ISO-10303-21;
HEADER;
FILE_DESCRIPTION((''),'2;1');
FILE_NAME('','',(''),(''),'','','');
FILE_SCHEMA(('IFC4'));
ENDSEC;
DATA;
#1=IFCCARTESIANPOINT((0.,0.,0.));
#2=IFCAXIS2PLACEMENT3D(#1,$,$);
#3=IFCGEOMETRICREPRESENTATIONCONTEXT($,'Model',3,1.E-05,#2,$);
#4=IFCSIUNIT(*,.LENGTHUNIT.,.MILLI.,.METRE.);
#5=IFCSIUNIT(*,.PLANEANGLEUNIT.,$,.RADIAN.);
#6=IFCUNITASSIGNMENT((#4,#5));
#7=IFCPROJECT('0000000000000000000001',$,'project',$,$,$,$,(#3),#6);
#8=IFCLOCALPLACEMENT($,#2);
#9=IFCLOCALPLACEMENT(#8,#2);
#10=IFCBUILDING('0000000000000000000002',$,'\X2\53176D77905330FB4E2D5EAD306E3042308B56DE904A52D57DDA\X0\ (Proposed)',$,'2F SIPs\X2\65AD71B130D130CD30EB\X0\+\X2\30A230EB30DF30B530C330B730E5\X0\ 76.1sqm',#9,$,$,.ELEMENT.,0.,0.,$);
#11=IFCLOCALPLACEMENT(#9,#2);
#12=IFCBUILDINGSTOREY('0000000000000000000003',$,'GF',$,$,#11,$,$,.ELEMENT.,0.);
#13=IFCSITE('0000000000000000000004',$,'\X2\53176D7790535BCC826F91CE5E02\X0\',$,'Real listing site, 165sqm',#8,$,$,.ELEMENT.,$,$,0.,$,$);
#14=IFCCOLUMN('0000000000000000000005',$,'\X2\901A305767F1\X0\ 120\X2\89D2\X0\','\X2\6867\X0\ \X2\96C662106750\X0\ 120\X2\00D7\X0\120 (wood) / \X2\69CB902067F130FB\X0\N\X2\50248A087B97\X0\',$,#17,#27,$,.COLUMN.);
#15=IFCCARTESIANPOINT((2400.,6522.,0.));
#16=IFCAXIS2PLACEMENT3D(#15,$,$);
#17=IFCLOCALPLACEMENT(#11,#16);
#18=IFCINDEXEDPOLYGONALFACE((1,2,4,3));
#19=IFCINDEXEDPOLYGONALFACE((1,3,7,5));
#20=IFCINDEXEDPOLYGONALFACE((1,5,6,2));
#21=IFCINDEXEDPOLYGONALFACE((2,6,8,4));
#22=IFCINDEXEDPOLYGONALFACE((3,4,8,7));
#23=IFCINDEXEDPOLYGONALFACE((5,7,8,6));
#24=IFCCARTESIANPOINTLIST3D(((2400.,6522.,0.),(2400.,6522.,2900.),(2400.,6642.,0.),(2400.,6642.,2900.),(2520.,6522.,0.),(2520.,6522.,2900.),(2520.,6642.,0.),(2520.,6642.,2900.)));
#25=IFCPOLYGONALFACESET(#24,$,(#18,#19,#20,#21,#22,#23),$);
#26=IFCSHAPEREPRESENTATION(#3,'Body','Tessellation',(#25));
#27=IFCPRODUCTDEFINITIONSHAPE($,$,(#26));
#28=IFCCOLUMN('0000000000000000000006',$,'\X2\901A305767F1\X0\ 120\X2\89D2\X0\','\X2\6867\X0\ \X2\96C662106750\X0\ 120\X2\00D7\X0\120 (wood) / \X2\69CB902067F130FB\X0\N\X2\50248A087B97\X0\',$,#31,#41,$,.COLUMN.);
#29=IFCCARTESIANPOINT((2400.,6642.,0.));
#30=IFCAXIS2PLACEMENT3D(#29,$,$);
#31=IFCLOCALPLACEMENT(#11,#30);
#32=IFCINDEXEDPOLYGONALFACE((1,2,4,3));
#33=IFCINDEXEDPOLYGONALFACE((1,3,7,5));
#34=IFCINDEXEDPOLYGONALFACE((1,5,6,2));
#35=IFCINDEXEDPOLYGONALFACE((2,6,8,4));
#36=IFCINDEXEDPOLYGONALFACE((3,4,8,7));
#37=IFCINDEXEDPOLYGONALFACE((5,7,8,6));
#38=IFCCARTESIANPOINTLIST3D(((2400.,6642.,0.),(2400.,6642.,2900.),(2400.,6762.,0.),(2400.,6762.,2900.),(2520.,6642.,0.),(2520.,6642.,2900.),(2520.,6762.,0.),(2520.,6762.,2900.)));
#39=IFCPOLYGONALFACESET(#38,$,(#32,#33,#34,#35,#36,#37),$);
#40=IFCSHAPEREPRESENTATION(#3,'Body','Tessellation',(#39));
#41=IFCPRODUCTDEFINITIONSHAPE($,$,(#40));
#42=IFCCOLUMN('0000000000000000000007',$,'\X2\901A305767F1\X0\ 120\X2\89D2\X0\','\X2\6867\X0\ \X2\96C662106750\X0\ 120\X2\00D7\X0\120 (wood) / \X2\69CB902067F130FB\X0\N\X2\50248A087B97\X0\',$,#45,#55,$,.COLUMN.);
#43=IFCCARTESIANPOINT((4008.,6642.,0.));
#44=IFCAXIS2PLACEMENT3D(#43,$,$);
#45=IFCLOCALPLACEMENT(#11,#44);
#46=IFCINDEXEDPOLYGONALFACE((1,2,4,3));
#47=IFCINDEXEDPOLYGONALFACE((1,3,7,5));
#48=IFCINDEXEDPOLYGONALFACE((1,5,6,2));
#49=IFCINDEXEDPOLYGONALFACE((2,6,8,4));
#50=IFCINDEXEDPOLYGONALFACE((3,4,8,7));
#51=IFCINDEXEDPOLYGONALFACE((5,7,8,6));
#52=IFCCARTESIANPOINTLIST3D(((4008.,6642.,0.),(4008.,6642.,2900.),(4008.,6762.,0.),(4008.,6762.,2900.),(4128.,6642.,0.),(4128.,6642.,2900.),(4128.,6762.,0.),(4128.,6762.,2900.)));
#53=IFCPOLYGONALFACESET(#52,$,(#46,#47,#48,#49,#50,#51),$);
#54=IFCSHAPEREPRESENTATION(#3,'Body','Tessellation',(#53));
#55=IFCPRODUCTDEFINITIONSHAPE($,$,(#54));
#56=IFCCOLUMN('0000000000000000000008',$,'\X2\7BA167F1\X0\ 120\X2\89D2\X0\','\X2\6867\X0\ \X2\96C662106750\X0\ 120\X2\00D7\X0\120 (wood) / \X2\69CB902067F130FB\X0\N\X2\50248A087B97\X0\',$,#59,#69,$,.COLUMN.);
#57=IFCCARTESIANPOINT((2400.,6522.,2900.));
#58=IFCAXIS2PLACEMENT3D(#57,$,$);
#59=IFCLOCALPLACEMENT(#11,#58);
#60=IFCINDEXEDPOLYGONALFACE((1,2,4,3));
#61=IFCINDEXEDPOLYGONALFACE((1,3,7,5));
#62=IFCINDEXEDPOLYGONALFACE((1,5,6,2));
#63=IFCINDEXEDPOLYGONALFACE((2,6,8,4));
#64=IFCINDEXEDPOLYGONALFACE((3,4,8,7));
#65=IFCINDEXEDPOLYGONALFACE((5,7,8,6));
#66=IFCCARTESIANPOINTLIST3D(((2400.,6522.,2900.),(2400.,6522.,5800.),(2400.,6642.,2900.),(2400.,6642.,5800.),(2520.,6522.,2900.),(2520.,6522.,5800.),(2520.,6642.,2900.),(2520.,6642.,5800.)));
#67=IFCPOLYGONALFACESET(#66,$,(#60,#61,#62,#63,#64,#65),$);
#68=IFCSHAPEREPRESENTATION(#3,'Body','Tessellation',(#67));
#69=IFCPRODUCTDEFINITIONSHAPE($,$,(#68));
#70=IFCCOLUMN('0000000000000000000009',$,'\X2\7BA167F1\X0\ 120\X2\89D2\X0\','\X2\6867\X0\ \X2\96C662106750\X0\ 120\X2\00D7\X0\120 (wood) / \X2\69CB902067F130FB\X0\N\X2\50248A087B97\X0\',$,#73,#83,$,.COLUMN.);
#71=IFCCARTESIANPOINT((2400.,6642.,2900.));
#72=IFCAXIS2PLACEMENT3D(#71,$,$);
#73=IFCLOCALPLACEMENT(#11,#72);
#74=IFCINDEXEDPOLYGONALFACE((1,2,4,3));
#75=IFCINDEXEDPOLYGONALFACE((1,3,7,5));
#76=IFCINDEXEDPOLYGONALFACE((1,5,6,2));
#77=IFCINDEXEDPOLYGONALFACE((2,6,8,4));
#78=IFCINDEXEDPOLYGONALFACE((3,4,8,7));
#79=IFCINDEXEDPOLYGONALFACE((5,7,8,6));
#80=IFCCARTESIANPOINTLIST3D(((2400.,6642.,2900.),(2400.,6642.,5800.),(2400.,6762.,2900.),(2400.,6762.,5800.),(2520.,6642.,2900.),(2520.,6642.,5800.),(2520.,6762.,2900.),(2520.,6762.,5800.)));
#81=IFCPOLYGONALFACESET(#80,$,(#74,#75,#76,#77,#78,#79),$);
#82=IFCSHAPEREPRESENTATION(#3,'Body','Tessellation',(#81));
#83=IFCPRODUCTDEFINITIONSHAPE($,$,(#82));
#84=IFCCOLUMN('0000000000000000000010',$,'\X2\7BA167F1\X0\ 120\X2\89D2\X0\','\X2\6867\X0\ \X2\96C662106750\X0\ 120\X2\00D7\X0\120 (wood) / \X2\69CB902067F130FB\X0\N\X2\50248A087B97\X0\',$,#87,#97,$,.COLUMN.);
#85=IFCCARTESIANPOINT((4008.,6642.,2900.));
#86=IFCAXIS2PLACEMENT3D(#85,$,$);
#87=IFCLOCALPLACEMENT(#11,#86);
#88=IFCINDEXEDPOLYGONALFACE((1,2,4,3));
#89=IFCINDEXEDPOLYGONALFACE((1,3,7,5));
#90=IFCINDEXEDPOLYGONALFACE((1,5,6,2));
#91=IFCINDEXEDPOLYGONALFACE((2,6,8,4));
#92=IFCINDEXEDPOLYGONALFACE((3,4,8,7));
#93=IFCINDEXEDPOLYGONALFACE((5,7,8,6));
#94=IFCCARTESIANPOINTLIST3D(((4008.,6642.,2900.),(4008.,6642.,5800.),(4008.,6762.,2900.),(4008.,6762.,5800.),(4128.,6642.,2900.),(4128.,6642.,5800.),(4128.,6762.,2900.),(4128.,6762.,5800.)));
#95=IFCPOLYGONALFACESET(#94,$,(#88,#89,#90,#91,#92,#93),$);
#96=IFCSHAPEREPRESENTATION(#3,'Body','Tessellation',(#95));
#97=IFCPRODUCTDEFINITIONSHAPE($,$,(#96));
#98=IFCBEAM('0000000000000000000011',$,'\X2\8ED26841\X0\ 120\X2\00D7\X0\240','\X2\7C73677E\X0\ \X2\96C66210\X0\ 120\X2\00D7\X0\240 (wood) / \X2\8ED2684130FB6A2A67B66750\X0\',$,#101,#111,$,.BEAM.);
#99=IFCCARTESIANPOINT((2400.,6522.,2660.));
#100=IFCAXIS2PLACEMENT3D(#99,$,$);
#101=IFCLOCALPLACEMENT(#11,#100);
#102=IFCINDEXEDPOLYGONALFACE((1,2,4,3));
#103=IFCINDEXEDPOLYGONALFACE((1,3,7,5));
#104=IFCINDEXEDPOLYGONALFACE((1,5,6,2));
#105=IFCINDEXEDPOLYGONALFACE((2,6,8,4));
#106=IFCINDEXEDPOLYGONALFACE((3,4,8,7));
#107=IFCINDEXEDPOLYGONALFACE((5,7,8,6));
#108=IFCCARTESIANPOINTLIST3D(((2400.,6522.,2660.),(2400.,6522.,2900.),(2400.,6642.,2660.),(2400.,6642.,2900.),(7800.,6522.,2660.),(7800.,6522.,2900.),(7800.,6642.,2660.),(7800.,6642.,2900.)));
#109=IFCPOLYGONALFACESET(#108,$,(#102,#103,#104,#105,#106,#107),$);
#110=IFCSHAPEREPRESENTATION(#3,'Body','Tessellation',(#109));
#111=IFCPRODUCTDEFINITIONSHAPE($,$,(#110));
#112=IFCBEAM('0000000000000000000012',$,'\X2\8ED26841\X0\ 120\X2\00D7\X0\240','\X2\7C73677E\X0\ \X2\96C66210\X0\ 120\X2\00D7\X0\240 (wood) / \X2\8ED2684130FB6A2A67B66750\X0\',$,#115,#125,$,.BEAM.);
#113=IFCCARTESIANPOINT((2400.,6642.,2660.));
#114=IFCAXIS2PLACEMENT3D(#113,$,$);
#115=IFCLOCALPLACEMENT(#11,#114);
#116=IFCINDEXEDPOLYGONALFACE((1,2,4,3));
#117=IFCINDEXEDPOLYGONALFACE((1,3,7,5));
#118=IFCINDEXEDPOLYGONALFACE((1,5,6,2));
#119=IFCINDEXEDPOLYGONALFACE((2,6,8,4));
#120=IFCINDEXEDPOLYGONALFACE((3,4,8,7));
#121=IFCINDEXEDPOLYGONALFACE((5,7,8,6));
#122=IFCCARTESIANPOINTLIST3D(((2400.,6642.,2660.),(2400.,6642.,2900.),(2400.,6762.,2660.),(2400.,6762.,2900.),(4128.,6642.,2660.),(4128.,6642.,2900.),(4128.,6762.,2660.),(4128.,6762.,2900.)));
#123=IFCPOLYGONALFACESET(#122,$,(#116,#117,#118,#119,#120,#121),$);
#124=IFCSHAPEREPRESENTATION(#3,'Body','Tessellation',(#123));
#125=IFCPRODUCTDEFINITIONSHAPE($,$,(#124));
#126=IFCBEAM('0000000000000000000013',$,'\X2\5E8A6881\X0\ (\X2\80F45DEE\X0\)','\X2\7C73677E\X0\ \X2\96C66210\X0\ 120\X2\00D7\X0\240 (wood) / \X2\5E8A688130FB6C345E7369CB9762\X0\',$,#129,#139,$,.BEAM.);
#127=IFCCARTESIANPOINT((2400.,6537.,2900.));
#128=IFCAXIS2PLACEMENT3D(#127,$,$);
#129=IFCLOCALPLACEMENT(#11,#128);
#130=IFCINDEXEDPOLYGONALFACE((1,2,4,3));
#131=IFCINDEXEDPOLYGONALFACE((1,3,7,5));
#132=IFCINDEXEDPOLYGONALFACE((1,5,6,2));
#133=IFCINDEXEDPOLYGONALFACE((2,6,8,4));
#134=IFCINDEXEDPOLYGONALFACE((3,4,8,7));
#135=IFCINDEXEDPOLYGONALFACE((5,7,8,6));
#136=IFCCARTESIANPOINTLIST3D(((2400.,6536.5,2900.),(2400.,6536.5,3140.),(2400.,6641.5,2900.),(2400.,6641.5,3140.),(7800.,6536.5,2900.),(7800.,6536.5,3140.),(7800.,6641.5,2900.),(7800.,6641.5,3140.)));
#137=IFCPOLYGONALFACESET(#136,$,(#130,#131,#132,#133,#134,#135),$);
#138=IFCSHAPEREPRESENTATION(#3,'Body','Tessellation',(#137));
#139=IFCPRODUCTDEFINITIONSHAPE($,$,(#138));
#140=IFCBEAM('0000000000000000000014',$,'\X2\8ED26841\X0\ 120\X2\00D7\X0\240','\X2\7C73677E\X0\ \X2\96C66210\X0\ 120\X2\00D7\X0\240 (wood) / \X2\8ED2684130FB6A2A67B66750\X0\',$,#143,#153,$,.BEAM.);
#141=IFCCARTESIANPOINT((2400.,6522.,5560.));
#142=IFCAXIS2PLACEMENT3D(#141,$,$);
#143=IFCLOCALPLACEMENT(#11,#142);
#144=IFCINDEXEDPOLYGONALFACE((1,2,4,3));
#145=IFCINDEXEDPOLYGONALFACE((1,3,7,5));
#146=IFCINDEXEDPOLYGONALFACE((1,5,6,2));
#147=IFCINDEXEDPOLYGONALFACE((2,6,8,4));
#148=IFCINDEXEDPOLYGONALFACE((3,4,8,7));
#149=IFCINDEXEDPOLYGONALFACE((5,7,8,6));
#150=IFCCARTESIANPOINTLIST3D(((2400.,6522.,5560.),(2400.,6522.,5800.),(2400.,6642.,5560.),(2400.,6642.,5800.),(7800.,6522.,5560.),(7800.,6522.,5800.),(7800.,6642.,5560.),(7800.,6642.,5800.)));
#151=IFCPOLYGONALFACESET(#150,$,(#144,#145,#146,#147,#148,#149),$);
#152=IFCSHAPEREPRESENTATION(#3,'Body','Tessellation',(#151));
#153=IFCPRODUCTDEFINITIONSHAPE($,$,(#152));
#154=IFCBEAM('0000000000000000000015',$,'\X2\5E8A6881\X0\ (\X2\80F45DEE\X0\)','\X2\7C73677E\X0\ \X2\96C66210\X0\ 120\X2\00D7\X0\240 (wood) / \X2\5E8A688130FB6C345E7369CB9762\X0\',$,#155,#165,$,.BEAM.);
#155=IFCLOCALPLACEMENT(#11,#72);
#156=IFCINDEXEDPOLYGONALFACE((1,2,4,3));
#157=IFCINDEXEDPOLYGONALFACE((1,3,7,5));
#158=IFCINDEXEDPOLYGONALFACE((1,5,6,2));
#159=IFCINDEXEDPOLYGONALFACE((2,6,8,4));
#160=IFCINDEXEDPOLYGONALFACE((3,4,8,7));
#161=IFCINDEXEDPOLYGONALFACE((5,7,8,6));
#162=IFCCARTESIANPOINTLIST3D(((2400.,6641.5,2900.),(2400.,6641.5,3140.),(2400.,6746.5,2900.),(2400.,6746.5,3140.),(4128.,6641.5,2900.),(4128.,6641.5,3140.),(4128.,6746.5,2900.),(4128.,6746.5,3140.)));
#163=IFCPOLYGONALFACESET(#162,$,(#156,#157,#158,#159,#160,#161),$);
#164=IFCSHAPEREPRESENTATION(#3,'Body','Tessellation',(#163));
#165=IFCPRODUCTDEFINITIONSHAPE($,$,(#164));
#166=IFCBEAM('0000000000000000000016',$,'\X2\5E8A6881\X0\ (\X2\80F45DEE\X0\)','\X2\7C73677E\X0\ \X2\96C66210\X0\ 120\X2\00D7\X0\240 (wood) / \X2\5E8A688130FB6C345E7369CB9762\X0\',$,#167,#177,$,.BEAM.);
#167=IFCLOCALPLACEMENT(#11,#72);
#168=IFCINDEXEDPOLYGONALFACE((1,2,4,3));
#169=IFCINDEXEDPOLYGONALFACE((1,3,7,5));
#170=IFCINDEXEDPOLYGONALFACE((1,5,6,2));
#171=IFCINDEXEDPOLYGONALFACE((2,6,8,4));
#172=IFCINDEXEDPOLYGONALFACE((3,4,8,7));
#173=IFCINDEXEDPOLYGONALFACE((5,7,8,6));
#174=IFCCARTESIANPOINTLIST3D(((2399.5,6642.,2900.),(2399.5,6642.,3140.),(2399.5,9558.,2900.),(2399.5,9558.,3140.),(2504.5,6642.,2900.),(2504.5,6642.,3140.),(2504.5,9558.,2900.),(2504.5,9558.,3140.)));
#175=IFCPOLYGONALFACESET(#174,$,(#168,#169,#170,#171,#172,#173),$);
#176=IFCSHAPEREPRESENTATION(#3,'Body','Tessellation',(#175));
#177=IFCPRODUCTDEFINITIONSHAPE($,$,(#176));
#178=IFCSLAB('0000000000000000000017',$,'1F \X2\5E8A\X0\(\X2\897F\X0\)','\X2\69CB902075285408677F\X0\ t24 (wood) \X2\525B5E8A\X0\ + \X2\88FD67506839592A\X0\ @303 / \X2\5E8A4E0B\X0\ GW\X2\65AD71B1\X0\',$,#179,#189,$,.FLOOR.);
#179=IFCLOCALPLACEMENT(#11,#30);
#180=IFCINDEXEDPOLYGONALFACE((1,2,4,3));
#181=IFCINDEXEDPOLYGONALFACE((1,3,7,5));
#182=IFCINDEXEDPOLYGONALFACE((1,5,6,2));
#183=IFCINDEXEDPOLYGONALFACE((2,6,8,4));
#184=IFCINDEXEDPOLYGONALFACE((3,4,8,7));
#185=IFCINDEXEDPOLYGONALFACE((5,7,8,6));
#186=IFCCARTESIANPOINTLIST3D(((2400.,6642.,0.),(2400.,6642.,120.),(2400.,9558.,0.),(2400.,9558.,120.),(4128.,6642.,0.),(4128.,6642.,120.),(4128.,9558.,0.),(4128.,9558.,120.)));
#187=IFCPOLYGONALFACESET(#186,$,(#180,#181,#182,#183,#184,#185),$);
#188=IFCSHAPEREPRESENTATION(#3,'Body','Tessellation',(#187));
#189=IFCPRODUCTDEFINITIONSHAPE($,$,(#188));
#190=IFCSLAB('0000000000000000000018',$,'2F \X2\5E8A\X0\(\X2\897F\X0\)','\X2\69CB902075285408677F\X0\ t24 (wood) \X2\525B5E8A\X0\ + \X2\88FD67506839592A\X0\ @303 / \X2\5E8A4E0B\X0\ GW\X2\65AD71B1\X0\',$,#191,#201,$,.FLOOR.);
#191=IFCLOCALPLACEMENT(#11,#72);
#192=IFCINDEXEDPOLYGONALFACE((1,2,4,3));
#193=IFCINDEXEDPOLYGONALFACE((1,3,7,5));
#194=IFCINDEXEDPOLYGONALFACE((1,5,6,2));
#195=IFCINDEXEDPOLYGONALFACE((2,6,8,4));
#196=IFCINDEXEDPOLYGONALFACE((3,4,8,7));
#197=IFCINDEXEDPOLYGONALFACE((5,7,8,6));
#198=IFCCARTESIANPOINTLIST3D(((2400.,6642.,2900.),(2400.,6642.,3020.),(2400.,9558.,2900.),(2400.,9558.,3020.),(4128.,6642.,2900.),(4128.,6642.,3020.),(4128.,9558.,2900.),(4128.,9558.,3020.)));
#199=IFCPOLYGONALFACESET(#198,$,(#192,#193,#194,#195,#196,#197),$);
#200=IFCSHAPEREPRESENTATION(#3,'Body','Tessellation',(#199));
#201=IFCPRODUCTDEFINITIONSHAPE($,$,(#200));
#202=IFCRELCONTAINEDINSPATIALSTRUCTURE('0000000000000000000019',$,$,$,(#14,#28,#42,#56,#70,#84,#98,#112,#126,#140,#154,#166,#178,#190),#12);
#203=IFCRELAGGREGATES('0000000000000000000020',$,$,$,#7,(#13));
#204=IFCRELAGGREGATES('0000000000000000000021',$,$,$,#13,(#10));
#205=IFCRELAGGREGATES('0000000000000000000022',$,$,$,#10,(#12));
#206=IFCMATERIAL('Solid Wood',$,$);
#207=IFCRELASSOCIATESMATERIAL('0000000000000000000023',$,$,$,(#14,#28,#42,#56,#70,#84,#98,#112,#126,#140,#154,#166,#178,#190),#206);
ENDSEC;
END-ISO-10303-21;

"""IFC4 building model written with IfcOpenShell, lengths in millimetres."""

from ifc_helpers import new_model, si_unit, frame, frame_2d, origin, place, context, project, spatial, rectangle, extrude, material, element, save


model = new_model("IFC4")

# Units and contexts
model_context = context("Model", 3, precision=1e-05, world=origin())
ifc_project = project(units=[si_unit("LENGTHUNIT", "METRE", prefix="MILLI"), si_unit("PLANEANGLEUNIT", "RADIAN")], contexts=[model_context])

# Site, building, storey
site_placement = place(None, origin())
site = spatial("IfcSite", under=ifc_project, at=site_placement, Name="北海道富良野市", ObjectType="Real listing site, 165sqm", CompositionType="ELEMENT", RefElevation=0.0)
building_placement = place(site_placement, origin())
building = spatial("IfcBuilding", under=site, at=building_placement, Name="北海道・中庭のある回遊動線 (Proposed)", ObjectType="2F SIPs断熱パネル+アルミサッシュ 76.1sqm", CompositionType="ELEMENT", ElevationOfRefHeight=0.0, ElevationOfTerrain=0.0)
storey_placement = place(building_placement, origin())
storey = spatial("IfcBuildingStorey", under=building, at=storey_placement, Name="GF", CompositionType="ELEMENT", Elevation=0.0)

# Columns
ifc_material_1 = material(Name="Solid Wood")
column_1_placement = place(storey_placement, frame((2400.0, 6522.0, 0.0)))
element("IfcColumn", 1, at=column_1_placement, inside=storey, material=ifc_material_1, Name="通し柱 120角", Description="桧 集成材 120×120 (wood) / 構造柱・N値計算", PredefinedType="COLUMN", context=model_context, shape_type="SweptSolid", body=[
    extrude(rectangle(XDim=120.0, YDim=120.0, at=frame_2d((60.0, 60.0))), frame((2400.0, 6522.0, 0.0)), (0.0, 0.0, 1.0), 2900.0),
])
column_2_placement = place(storey_placement, frame((2400.0, 6642.0, 0.0)))
element("IfcColumn", 2, at=column_2_placement, inside=storey, material=ifc_material_1, Name="通し柱 120角", Description="桧 集成材 120×120 (wood) / 構造柱・N値計算", PredefinedType="COLUMN", context=model_context, shape_type="SweptSolid", body=[
    extrude(rectangle(XDim=120.0, YDim=120.0, at=frame_2d((60.0, 60.0))), frame((2400.0, 6642.0, 0.0)), (0.0, 0.0, 1.0), 2900.0),
])
column_3_placement = place(storey_placement, frame((4008.0, 6642.0, 0.0)))
element("IfcColumn", 3, at=column_3_placement, inside=storey, material=ifc_material_1, Name="通し柱 120角", Description="桧 集成材 120×120 (wood) / 構造柱・N値計算", PredefinedType="COLUMN", context=model_context, shape_type="SweptSolid", body=[
    extrude(rectangle(XDim=120.0, YDim=120.0, at=frame_2d((60.0, 60.0))), frame((4008.0, 6642.0, 0.0)), (0.0, 0.0, 1.0), 2900.0),
])
column_4_placement = place(storey_placement, frame((2400.0, 6522.0, 2900.0)))
element("IfcColumn", 4, at=column_4_placement, inside=storey, material=ifc_material_1, Name="管柱 120角", Description="桧 集成材 120×120 (wood) / 構造柱・N値計算", PredefinedType="COLUMN", context=model_context, shape_type="SweptSolid", body=[
    extrude(rectangle(XDim=120.0, YDim=120.0, at=frame_2d((60.0, 60.0))), frame((2400.0, 6522.0, 2900.0)), (0.0, 0.0, 1.0), 2900.0),
])
column_5_placement = place(storey_placement, frame((2400.0, 6642.0, 2900.0)))
element("IfcColumn", 5, at=column_5_placement, inside=storey, material=ifc_material_1, Name="管柱 120角", Description="桧 集成材 120×120 (wood) / 構造柱・N値計算", PredefinedType="COLUMN", context=model_context, shape_type="SweptSolid", body=[
    extrude(rectangle(XDim=120.0, YDim=120.0, at=frame_2d((60.0, 60.0))), frame((2400.0, 6642.0, 2900.0)), (0.0, 0.0, 1.0), 2900.0),
])
column_6_placement = place(storey_placement, frame((4008.0, 6642.0, 2900.0)))
element("IfcColumn", 6, at=column_6_placement, inside=storey, material=ifc_material_1, Name="管柱 120角", Description="桧 集成材 120×120 (wood) / 構造柱・N値計算", PredefinedType="COLUMN", context=model_context, shape_type="SweptSolid", body=[
    extrude(rectangle(XDim=120.0, YDim=120.0, at=frame_2d((60.0, 60.0))), frame((4008.0, 6642.0, 2900.0)), (0.0, 0.0, 1.0), 2900.0),
])

# Beams
beam_1_placement = place(storey_placement, frame((2400.0, 6522.0, 2660.0)))
element("IfcBeam", 7, at=beam_1_placement, inside=storey, material=ifc_material_1, Name="軒桁 120×240", Description="米松 集成 120×240 (wood) / 軒桁・横架材", PredefinedType="BEAM", context=model_context, shape_type="SweptSolid", body=[
    extrude(rectangle(XDim=5400.0, YDim=120.0, at=frame_2d((2700.0, 60.0))), frame((2400.0, 6522.0, 2660.0)), (0.0, 0.0, 1.0), 240.0),
])
beam_2_placement = place(storey_placement, frame((2400.0, 6642.0, 2660.0)))
element("IfcBeam", 8, at=beam_2_placement, inside=storey, material=ifc_material_1, Name="軒桁 120×240", Description="米松 集成 120×240 (wood) / 軒桁・横架材", PredefinedType="BEAM", context=model_context, shape_type="SweptSolid", body=[
    extrude(rectangle(XDim=1728.0, YDim=120.0, at=frame_2d((864.0, 60.0))), frame((2400.0, 6642.0, 2660.0)), (0.0, 0.0, 1.0), 240.0),
])
beam_3_placement = place(storey_placement, frame((2400.0, 6537.0, 2900.0)))
element("IfcBeam", 9, at=beam_3_placement, inside=storey, material=ifc_material_1, Name="床梁 (胴差)", Description="米松 集成 120×240 (wood) / 床梁・水平構面", PredefinedType="BEAM", context=model_context, shape_type="SweptSolid", body=[
    extrude(rectangle(XDim=5400.0, YDim=105.0, at=frame_2d((2700.0, 52.0))), frame((2400.0, 6537.0, 2900.0)), (0.0, 0.0, 1.0), 240.0),
])
beam_4_placement = place(storey_placement, frame((2400.0, 6522.0, 5560.0)))
element("IfcBeam", 10, at=beam_4_placement, inside=storey, material=ifc_material_1, Name="軒桁 120×240", Description="米松 集成 120×240 (wood) / 軒桁・横架材", PredefinedType="BEAM", context=model_context, shape_type="SweptSolid", body=[
    extrude(rectangle(XDim=5400.0, YDim=120.0, at=frame_2d((2700.0, 60.0))), frame((2400.0, 6522.0, 5560.0)), (0.0, 0.0, 1.0), 240.0),
])
beam_5_placement = place(storey_placement, frame((2400.0, 6642.0, 2900.0)))
element("IfcBeam", 11, at=beam_5_placement, inside=storey, material=ifc_material_1, Name="床梁 (胴差)", Description="米松 集成 120×240 (wood) / 床梁・水平構面", PredefinedType="BEAM", context=model_context, shape_type="SweptSolid", body=[
    extrude(rectangle(XDim=1728.0, YDim=105.0, at=frame_2d((864.0, 52.0))), frame((2400.0, 6642.0, 2900.0)), (0.0, 0.0, 1.0), 240.0),
])
beam_6_placement = place(storey_placement, frame((2400.0, 6642.0, 2900.0)))
element("IfcBeam", 12, at=beam_6_placement, inside=storey, material=ifc_material_1, Name="床梁 (胴差)", Description="米松 集成 120×240 (wood) / 床梁・水平構面", PredefinedType="BEAM", context=model_context, shape_type="SweptSolid", body=[
    extrude(rectangle(XDim=105.0, YDim=2916.0, at=frame_2d((52.0, 1458.0))), frame((2400.0, 6642.0, 2900.0)), (0.0, 0.0, 1.0), 240.0),
])

# Slabs
slab_1_placement = place(storey_placement, frame((2400.0, 6642.0, 0.0)))
element("IfcSlab", 13, at=slab_1_placement, inside=storey, material=ifc_material_1, Name="1F 床(西)", Description="構造用合板 t24 (wood) 剛床 + 製材根太 @303 / 床下 GW断熱", PredefinedType="FLOOR", context=model_context, shape_type="SweptSolid", body=[
    extrude(rectangle(XDim=1728.0, YDim=2916.0, at=frame_2d((864.0, 1458.0))), frame((2400.0, 6642.0, 0.0)), (0.0, 0.0, 1.0), 120.0),
])
slab_2_placement = place(storey_placement, frame((2400.0, 6642.0, 2900.0)))
element("IfcSlab", 14, at=slab_2_placement, inside=storey, material=ifc_material_1, Name="2F 床(西)", Description="構造用合板 t24 (wood) 剛床 + 製材根太 @303 / 床下 GW断熱", PredefinedType="FLOOR", context=model_context, shape_type="SweptSolid", body=[
    extrude(rectangle(XDim=1728.0, YDim=2916.0, at=frame_2d((864.0, 1458.0))), frame((2400.0, 6642.0, 2900.0)), (0.0, 0.0, 1.0), 120.0),
])

save(model, "model.ifc")
